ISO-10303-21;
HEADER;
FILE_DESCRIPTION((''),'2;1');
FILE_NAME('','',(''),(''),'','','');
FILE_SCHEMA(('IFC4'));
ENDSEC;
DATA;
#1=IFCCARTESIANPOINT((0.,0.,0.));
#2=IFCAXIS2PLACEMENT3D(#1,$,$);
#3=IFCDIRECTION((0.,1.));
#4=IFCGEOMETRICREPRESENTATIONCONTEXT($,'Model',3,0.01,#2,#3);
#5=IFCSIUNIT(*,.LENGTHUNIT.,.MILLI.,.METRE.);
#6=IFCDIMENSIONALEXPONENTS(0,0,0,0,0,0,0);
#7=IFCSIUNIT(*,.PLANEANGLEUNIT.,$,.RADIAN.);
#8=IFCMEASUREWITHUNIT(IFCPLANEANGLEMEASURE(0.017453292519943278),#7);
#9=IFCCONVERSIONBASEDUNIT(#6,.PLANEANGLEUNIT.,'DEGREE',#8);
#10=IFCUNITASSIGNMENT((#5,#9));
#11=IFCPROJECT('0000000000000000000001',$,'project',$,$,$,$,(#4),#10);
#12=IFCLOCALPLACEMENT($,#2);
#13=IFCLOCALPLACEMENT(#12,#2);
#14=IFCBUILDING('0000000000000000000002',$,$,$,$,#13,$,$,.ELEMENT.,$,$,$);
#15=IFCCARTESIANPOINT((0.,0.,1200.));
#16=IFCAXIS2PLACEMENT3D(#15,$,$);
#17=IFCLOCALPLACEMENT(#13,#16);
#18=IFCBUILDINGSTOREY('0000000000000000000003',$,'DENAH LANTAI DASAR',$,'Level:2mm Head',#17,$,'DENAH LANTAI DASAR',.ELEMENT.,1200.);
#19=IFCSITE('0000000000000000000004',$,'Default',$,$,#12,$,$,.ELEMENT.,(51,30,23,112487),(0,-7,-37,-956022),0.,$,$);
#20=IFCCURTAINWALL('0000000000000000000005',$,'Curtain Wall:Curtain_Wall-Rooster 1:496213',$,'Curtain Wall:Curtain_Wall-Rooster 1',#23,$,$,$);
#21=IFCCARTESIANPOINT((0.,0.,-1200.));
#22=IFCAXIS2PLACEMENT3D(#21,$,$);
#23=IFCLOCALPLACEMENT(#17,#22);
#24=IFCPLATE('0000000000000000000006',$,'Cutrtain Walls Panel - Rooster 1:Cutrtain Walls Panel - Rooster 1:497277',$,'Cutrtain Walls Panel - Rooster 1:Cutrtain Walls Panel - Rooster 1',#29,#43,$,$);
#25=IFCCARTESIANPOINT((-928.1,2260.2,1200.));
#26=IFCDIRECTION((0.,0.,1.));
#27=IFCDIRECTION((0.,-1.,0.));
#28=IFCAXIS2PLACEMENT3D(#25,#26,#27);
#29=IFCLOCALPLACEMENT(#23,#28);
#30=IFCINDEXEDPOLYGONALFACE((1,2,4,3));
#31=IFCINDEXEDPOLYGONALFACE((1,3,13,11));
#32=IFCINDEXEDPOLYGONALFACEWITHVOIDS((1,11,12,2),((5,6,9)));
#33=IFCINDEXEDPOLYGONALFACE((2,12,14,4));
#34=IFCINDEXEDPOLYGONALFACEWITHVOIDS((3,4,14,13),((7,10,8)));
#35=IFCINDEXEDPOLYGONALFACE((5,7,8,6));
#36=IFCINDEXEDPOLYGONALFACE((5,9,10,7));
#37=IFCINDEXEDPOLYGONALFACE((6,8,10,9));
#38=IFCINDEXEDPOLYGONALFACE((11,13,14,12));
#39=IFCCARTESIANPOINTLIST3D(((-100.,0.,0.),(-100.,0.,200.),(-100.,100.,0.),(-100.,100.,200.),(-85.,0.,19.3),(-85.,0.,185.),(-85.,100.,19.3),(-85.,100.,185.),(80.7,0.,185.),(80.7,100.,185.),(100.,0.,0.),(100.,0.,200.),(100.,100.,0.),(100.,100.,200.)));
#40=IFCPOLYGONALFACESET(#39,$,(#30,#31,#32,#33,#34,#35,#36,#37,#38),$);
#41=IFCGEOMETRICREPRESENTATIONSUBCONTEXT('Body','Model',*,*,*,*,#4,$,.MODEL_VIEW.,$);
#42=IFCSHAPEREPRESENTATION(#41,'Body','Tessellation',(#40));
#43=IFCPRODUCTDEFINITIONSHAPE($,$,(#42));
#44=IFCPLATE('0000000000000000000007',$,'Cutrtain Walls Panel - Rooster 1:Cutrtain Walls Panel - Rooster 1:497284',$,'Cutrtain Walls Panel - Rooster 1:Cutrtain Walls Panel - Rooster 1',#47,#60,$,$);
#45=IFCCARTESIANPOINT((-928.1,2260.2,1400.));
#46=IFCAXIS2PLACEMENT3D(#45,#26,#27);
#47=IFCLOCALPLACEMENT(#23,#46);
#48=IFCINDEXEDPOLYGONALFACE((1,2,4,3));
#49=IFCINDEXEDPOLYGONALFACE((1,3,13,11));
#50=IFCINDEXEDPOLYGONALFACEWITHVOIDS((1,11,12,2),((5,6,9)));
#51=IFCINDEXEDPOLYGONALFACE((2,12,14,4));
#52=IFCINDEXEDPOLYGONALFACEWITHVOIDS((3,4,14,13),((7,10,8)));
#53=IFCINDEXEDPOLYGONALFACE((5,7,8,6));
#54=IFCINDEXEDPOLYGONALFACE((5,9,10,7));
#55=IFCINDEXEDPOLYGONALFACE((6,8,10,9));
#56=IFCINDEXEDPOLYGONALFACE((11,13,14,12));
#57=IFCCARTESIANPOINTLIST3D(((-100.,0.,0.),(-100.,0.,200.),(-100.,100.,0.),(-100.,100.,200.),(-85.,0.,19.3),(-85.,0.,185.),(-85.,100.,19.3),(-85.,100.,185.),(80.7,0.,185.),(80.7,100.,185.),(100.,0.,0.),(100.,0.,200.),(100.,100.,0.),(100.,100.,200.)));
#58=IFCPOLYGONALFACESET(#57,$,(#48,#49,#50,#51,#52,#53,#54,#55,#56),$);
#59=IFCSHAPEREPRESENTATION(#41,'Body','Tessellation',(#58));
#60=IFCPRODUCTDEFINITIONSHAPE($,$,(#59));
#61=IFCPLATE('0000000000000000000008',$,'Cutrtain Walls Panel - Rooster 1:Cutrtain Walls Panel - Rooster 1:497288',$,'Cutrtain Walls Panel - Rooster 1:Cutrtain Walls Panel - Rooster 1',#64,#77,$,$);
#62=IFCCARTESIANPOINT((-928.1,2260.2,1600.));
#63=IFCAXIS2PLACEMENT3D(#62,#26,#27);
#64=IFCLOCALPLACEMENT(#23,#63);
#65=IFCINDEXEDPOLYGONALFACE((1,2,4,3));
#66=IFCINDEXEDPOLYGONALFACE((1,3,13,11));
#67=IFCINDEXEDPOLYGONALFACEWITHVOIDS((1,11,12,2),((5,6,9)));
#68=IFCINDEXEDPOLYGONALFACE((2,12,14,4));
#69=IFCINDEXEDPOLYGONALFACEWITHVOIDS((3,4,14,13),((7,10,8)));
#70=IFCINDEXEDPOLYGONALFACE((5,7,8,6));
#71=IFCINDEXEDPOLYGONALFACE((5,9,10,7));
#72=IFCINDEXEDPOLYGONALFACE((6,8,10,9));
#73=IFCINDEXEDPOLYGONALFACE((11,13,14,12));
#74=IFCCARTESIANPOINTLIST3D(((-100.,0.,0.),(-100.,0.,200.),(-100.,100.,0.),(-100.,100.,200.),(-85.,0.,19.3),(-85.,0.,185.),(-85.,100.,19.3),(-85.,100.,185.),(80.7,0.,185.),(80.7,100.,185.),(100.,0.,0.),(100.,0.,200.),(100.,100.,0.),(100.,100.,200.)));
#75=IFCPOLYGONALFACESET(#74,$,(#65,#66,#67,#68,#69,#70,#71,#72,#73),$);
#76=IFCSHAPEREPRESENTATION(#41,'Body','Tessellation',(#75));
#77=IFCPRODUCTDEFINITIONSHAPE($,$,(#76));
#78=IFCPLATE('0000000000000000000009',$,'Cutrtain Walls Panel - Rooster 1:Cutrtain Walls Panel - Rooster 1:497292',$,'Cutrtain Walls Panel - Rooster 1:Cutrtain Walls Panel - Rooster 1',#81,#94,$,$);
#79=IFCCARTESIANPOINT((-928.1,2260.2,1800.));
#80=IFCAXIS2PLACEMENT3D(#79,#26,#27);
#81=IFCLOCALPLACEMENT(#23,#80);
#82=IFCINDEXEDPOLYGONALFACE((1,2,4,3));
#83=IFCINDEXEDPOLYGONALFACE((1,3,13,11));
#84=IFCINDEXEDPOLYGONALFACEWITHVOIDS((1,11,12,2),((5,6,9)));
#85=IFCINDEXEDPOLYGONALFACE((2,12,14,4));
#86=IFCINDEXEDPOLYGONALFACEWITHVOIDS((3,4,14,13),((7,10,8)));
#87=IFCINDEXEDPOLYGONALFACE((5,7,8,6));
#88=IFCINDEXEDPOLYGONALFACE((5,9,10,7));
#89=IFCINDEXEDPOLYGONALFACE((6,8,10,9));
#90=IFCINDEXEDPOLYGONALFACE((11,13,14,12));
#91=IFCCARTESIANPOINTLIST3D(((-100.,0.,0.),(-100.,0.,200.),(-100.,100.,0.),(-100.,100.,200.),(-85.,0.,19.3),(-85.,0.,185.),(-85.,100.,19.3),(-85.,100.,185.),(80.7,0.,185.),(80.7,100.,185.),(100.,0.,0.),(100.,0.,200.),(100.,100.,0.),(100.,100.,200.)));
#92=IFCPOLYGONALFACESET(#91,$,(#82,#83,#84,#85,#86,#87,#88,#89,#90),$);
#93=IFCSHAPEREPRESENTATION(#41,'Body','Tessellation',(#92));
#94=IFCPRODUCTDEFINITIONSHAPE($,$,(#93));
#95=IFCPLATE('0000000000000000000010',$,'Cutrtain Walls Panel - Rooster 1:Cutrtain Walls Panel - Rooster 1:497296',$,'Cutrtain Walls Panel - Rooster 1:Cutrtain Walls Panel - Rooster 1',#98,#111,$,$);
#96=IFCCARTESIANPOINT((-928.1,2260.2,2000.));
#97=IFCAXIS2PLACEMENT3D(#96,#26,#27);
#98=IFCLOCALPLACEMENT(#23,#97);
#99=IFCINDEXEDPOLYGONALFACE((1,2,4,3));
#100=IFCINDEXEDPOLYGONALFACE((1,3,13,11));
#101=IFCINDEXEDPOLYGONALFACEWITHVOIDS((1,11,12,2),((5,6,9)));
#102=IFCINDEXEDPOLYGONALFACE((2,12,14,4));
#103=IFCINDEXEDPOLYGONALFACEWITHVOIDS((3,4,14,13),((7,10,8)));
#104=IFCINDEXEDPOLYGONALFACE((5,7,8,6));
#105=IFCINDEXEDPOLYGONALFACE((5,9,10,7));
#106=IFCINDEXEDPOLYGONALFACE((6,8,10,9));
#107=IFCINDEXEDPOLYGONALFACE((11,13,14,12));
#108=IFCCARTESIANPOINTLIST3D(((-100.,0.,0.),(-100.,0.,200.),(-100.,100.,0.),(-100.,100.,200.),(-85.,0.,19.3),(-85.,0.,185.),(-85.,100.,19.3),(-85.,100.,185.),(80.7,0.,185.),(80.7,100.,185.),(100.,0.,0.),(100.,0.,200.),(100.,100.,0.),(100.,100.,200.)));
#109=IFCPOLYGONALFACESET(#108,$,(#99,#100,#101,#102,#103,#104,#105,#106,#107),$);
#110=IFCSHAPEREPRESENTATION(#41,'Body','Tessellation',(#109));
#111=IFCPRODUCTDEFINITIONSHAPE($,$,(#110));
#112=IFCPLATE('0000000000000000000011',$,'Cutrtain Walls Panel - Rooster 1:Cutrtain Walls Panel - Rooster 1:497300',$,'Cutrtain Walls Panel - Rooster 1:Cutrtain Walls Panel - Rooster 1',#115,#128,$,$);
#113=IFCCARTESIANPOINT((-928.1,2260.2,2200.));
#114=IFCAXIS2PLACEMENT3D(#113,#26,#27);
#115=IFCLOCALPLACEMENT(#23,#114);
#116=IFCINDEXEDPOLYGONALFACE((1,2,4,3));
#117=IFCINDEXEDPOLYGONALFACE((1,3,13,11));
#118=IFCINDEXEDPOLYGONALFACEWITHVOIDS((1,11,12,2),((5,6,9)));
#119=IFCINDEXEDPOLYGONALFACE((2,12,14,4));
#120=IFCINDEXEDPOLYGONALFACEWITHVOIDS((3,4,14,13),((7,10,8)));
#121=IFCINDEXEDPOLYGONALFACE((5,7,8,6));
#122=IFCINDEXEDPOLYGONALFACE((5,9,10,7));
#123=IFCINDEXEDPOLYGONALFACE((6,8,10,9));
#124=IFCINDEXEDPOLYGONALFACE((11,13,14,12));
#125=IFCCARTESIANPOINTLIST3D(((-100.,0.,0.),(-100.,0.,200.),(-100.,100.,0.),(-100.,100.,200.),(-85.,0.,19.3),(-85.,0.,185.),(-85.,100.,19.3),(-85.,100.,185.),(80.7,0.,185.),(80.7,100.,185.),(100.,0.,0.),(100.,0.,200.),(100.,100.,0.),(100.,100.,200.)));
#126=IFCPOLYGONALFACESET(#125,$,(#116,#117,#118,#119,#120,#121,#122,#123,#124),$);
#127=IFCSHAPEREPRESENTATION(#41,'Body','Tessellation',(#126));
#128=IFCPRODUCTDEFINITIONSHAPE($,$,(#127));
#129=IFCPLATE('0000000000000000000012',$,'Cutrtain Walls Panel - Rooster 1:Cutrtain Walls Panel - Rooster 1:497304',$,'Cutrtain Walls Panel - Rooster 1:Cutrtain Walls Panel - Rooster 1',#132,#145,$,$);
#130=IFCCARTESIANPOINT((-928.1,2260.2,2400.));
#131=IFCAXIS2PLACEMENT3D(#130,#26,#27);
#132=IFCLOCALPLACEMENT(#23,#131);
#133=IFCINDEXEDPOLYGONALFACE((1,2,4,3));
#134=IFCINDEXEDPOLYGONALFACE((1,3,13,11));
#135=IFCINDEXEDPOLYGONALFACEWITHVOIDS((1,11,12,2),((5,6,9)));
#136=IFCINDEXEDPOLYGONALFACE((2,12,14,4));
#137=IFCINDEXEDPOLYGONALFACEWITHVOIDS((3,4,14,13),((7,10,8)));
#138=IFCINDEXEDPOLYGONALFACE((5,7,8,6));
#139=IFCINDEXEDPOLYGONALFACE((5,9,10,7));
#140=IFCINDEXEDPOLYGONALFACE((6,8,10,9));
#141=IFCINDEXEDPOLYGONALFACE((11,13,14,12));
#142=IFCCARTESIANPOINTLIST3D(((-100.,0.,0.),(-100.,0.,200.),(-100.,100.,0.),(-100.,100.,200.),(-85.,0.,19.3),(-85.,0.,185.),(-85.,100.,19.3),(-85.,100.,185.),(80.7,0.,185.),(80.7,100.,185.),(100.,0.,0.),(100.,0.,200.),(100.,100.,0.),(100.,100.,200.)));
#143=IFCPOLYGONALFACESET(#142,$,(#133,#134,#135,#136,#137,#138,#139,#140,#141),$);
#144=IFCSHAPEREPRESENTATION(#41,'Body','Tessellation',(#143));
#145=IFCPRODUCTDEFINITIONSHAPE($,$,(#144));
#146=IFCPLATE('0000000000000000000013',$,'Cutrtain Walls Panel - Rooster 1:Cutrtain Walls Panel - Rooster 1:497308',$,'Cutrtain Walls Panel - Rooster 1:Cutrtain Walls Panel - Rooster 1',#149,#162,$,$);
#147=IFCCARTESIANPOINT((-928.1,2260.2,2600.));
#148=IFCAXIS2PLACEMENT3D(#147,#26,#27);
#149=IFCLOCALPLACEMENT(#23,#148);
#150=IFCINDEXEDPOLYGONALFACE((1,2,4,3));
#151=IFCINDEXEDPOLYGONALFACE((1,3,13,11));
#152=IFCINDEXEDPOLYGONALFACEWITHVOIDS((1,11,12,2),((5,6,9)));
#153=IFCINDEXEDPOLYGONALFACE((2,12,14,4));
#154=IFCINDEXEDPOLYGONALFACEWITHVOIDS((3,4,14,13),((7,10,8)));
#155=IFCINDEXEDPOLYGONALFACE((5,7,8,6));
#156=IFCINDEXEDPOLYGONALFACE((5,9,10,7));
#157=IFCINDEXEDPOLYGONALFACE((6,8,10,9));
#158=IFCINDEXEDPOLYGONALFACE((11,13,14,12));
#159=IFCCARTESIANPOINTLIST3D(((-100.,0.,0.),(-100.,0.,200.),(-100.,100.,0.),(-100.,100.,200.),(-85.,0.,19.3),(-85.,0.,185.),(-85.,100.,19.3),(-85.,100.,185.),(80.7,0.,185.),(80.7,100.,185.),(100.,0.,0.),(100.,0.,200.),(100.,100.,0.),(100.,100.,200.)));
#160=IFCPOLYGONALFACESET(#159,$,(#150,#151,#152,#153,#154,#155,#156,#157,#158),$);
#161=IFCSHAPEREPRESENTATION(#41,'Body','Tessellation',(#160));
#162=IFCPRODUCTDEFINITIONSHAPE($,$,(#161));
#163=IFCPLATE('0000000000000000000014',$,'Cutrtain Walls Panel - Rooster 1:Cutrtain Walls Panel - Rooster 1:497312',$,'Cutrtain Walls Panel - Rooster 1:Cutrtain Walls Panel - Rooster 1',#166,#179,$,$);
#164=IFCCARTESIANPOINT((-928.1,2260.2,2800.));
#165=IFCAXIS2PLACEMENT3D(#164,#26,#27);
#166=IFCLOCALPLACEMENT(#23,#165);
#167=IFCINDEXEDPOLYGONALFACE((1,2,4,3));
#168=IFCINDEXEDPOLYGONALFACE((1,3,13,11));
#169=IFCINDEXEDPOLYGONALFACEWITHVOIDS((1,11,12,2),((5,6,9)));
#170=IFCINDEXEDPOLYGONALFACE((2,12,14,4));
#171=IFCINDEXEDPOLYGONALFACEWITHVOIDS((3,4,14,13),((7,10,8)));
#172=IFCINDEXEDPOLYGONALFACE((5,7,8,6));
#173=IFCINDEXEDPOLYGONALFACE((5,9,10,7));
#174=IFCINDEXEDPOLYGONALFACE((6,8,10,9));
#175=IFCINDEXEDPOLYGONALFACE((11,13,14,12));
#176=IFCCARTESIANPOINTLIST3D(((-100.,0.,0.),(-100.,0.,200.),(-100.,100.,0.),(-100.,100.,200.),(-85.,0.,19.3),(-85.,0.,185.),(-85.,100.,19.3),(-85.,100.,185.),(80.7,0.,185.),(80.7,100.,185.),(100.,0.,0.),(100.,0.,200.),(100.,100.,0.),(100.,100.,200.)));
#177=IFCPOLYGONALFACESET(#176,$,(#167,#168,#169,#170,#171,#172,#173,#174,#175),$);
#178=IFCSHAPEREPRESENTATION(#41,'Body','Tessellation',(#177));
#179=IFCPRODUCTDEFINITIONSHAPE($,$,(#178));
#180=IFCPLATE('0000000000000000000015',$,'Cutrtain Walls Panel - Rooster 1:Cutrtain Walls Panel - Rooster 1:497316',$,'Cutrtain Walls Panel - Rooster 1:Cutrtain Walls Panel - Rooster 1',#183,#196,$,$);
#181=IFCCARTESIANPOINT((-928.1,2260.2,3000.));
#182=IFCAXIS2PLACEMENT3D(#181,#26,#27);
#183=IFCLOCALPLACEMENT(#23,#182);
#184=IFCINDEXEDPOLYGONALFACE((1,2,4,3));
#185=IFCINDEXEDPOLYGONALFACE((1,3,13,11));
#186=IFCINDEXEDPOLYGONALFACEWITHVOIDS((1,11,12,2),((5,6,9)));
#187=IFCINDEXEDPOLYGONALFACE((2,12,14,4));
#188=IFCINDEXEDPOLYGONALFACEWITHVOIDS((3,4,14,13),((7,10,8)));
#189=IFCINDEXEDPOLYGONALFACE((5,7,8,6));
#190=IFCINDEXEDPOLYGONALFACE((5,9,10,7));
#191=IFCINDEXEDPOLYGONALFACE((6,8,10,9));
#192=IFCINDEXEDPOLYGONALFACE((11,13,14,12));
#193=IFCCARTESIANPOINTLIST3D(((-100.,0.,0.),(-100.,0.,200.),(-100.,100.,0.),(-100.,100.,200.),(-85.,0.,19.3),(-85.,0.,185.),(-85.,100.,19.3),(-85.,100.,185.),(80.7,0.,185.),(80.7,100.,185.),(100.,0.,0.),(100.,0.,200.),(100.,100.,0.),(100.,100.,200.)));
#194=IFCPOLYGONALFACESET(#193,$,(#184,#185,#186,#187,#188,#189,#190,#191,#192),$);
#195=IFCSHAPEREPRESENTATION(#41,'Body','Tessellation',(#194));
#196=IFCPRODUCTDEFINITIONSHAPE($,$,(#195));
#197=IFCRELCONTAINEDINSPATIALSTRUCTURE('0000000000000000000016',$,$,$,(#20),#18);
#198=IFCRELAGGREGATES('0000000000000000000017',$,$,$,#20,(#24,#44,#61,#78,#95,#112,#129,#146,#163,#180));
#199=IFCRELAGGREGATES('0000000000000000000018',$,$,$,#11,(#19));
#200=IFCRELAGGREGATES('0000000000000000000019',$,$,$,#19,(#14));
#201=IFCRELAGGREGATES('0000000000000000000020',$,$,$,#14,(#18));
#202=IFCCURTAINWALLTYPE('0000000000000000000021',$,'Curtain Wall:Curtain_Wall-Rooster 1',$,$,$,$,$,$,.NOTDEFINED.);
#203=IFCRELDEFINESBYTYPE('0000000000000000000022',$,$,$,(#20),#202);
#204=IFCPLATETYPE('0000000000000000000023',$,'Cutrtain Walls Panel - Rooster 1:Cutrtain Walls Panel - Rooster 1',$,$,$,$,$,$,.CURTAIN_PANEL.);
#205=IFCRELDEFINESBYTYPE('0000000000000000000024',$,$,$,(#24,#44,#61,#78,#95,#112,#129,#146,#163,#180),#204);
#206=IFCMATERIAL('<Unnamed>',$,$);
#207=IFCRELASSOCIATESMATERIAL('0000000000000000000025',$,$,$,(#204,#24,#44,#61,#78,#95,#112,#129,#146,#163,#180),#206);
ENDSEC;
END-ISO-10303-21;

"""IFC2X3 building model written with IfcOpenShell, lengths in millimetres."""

from ifc_helpers import new_model, entity, si_unit, converted_unit, direction, frame, origin, place, context, subcontext, project, spatial, polyline, outline, extrude, source, transform, mapped, material, type_object, type_shapes, element, aggregate, save


model = new_model("IFC2X3")

# Units and contexts
model_context = context("Model", 3, precision=0.01, world=origin(), true_north=direction((0.0, 1.0)))
body_context = subcontext(model_context, "Body", "Model", "MODEL_VIEW")
ifc_project = project(units=[si_unit("LENGTHUNIT", "METRE", prefix="MILLI"), converted_unit("PLANEANGLEUNIT", "DEGREE", entity("IfcPlaneAngleMeasure", 0.017453292519943278), si_unit("PLANEANGLEUNIT", "RADIAN"), dimensions=[0, 0, 0, 0, 0, 0, 0])], contexts=[model_context])

# Site, building, storey
site_placement = place(None, origin())
site = spatial("IfcSite", under=ifc_project, at=site_placement, Name="Default", CompositionType="ELEMENT", RefLatitude=(51, 30, 23, 112487), RefLongitude=(0, -7, -37, -956022), RefElevation=0.0)
building_placement = place(site_placement, origin())
building = spatial("IfcBuilding", under=site, at=building_placement, CompositionType="ELEMENT")
storey_placement = place(building_placement, frame((0.0, 0.0, 1200.0)))
storey = spatial("IfcBuildingStorey", under=building, at=storey_placement, Name="DENAH LANTAI DASAR", ObjectType="Level:2mm Head", LongName="DENAH LANTAI DASAR", CompositionType="ELEMENT", Elevation=1200.0)

# Curtain wall, plates
curtain_wall_type = type_object("IfcCurtainWallType", Name="Curtain Wall:Curtain_Wall-Rooster 1", PredefinedType="NOTDEFINED")
curtain_wall_1_placement = place(storey_placement, frame((0.0, 0.0, -1200.0)))
curtain_wall_1 = element("IfcCurtainWall", 1, at=curtain_wall_1_placement, inside=storey, type_object=curtain_wall_type, Name="Curtain Wall:Curtain_Wall-Rooster 1:496213", ObjectType="Curtain Wall:Curtain_Wall-Rooster 1")
ifc_material_1 = material(Name="<Unnamed>")
plate_type_1 = type_object("IfcPlateType", Name="Cutrtain Walls Panel - Rooster 1:Cutrtain Walls Panel - Rooster 1", PredefinedType="CURTAIN_PANEL", material=ifc_material_1)
shared_shape_1 = source(origin(), body_context, "Body", "SweptSolid", [
    extrude(outline(polyline([(-100.0, -100.0), (100.0, -100.0), (100.0, 100.0), (-100.0, 100.0), (-100.0, -100.0)]), holes=[polyline([(80.7, 85.0), (-85.0, -80.7), (-85.0, 85.0), (80.7, 85.0)])]), frame((0.0, 0.0, 100.0), z_axis=(0.0, 1.0, 0.0), x_axis=(0.0, 0.0, -1.0)), (0.0, 0.0, 1.0), 100.0),
])
type_shapes(plate_type_1, [shared_shape_1])
plate_1_placement = place(curtain_wall_1_placement, frame((-928.1, 2260.2, 1200.0), z_axis=(0.0, 0.0, 1.0), x_axis=(0.0, -1.0, 0.0)))
plate_1 = element("IfcPlate", 2, at=plate_1_placement, type_object=plate_type_1, material=ifc_material_1, Name="Cutrtain Walls Panel - Rooster 1:Cutrtain Walls Panel - Rooster 1:497277", ObjectType="Cutrtain Walls Panel - Rooster 1:Cutrtain Walls Panel - Rooster 1", context=body_context, shape_type="MappedRepresentation", body=[
    mapped(shared_shape_1, transform((0.0, 0.0, 0.0), scale=1.0)),
])
plate_2_placement = place(curtain_wall_1_placement, frame((-928.1, 2260.2, 1400.0), z_axis=(0.0, 0.0, 1.0), x_axis=(0.0, -1.0, 0.0)))
plate_2 = element("IfcPlate", 3, at=plate_2_placement, type_object=plate_type_1, material=ifc_material_1, Name="Cutrtain Walls Panel - Rooster 1:Cutrtain Walls Panel - Rooster 1:497284", ObjectType="Cutrtain Walls Panel - Rooster 1:Cutrtain Walls Panel - Rooster 1", context=body_context, shape_type="MappedRepresentation", body=[
    mapped(shared_shape_1, transform((0.0, 0.0, 0.0), scale=1.0)),
])
plate_3_placement = place(curtain_wall_1_placement, frame((-928.1, 2260.2, 1600.0), z_axis=(0.0, 0.0, 1.0), x_axis=(0.0, -1.0, 0.0)))
plate_3 = element("IfcPlate", 4, at=plate_3_placement, type_object=plate_type_1, material=ifc_material_1, Name="Cutrtain Walls Panel - Rooster 1:Cutrtain Walls Panel - Rooster 1:497288", ObjectType="Cutrtain Walls Panel - Rooster 1:Cutrtain Walls Panel - Rooster 1", context=body_context, shape_type="MappedRepresentation", body=[
    mapped(shared_shape_1, transform((0.0, 0.0, 0.0), scale=1.0)),
])
plate_4_placement = place(curtain_wall_1_placement, frame((-928.1, 2260.2, 1800.0), z_axis=(0.0, 0.0, 1.0), x_axis=(0.0, -1.0, 0.0)))
plate_4 = element("IfcPlate", 5, at=plate_4_placement, type_object=plate_type_1, material=ifc_material_1, Name="Cutrtain Walls Panel - Rooster 1:Cutrtain Walls Panel - Rooster 1:497292", ObjectType="Cutrtain Walls Panel - Rooster 1:Cutrtain Walls Panel - Rooster 1", context=body_context, shape_type="MappedRepresentation", body=[
    mapped(shared_shape_1, transform((0.0, 0.0, 0.0), scale=1.0)),
])
plate_5_placement = place(curtain_wall_1_placement, frame((-928.1, 2260.2, 2000.0), z_axis=(0.0, 0.0, 1.0), x_axis=(0.0, -1.0, 0.0)))
plate_5 = element("IfcPlate", 6, at=plate_5_placement, type_object=plate_type_1, material=ifc_material_1, Name="Cutrtain Walls Panel - Rooster 1:Cutrtain Walls Panel - Rooster 1:497296", ObjectType="Cutrtain Walls Panel - Rooster 1:Cutrtain Walls Panel - Rooster 1", context=body_context, shape_type="MappedRepresentation", body=[
    mapped(shared_shape_1, transform((0.0, 0.0, 0.0), scale=1.0)),
])
plate_6_placement = place(curtain_wall_1_placement, frame((-928.1, 2260.2, 2200.0), z_axis=(0.0, 0.0, 1.0), x_axis=(0.0, -1.0, 0.0)))
plate_6 = element("IfcPlate", 7, at=plate_6_placement, type_object=plate_type_1, material=ifc_material_1, Name="Cutrtain Walls Panel - Rooster 1:Cutrtain Walls Panel - Rooster 1:497300", ObjectType="Cutrtain Walls Panel - Rooster 1:Cutrtain Walls Panel - Rooster 1", context=body_context, shape_type="MappedRepresentation", body=[
    mapped(shared_shape_1, transform((0.0, 0.0, 0.0), scale=1.0)),
])
plate_7_placement = place(curtain_wall_1_placement, frame((-928.1, 2260.2, 2400.0), z_axis=(0.0, 0.0, 1.0), x_axis=(0.0, -1.0, 0.0)))
plate_7 = element("IfcPlate", 8, at=plate_7_placement, type_object=plate_type_1, material=ifc_material_1, Name="Cutrtain Walls Panel - Rooster 1:Cutrtain Walls Panel - Rooster 1:497304", ObjectType="Cutrtain Walls Panel - Rooster 1:Cutrtain Walls Panel - Rooster 1", context=body_context, shape_type="MappedRepresentation", body=[
    mapped(shared_shape_1, transform((0.0, 0.0, 0.0), scale=1.0)),
])
plate_8_placement = place(curtain_wall_1_placement, frame((-928.1, 2260.2, 2600.0), z_axis=(0.0, 0.0, 1.0), x_axis=(0.0, -1.0, 0.0)))
plate_8 = element("IfcPlate", 9, at=plate_8_placement, type_object=plate_type_1, material=ifc_material_1, Name="Cutrtain Walls Panel - Rooster 1:Cutrtain Walls Panel - Rooster 1:497308", ObjectType="Cutrtain Walls Panel - Rooster 1:Cutrtain Walls Panel - Rooster 1", context=body_context, shape_type="MappedRepresentation", body=[
    mapped(shared_shape_1, transform((0.0, 0.0, 0.0), scale=1.0)),
])
plate_9_placement = place(curtain_wall_1_placement, frame((-928.1, 2260.2, 2800.0), z_axis=(0.0, 0.0, 1.0), x_axis=(0.0, -1.0, 0.0)))
plate_9 = element("IfcPlate", 10, at=plate_9_placement, type_object=plate_type_1, material=ifc_material_1, Name="Cutrtain Walls Panel - Rooster 1:Cutrtain Walls Panel - Rooster 1:497312", ObjectType="Cutrtain Walls Panel - Rooster 1:Cutrtain Walls Panel - Rooster 1", context=body_context, shape_type="MappedRepresentation", body=[
    mapped(shared_shape_1, transform((0.0, 0.0, 0.0), scale=1.0)),
])
plate_10_placement = place(curtain_wall_1_placement, frame((-928.1, 2260.2, 3000.0), z_axis=(0.0, 0.0, 1.0), x_axis=(0.0, -1.0, 0.0)))
plate_10 = element("IfcPlate", 11, at=plate_10_placement, type_object=plate_type_1, material=ifc_material_1, Name="Cutrtain Walls Panel - Rooster 1:Cutrtain Walls Panel - Rooster 1:497316", ObjectType="Cutrtain Walls Panel - Rooster 1:Cutrtain Walls Panel - Rooster 1", context=body_context, shape_type="MappedRepresentation", body=[
    mapped(shared_shape_1, transform((0.0, 0.0, 0.0), scale=1.0)),
])
aggregate(curtain_wall_1, [plate_1, plate_2, plate_3, plate_4, plate_5, plate_6, plate_7, plate_8, plate_9, plate_10])

save(model, "model.ifc")
